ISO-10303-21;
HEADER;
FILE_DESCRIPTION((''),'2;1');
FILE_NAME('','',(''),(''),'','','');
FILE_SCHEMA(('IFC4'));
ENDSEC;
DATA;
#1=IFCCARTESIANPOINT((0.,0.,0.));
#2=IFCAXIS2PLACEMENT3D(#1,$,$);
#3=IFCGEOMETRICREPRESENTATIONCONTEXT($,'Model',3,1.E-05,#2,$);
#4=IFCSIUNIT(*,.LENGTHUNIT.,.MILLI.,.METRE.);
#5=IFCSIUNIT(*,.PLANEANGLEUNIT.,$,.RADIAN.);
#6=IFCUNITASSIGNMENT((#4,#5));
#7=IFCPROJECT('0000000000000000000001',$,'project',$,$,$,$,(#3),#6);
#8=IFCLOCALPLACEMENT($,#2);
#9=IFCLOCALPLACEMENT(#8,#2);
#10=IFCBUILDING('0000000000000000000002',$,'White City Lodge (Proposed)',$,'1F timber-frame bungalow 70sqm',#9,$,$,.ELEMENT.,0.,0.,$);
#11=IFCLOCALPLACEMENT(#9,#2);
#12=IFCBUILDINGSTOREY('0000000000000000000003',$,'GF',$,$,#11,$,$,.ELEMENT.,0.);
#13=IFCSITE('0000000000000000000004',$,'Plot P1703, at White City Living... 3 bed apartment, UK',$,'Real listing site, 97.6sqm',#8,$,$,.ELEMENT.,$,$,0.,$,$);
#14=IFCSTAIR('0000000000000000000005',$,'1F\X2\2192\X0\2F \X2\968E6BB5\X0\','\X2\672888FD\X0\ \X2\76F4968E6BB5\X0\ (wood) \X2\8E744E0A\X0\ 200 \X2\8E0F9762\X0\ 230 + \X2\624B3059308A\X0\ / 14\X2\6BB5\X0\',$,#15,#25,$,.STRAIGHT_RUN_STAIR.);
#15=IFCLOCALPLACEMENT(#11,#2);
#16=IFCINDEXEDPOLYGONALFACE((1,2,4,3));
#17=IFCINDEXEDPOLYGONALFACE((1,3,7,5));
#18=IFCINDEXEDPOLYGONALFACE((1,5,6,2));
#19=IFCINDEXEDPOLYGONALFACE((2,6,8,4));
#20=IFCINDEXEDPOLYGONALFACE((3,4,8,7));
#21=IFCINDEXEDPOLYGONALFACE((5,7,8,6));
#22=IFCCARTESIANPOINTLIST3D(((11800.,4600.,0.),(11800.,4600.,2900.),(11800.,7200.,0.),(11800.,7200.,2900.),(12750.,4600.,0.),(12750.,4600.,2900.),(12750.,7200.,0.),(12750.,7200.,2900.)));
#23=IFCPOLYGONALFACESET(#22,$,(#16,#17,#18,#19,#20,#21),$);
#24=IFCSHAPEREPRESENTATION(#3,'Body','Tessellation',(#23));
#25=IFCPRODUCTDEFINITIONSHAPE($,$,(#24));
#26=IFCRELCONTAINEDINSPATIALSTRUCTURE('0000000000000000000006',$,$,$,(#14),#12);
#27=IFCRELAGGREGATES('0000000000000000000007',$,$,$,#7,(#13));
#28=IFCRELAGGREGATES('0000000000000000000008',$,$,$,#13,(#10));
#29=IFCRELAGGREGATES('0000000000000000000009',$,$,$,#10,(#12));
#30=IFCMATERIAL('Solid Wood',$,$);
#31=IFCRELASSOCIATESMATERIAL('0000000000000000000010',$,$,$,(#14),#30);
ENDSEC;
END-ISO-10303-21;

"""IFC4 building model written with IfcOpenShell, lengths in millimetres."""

from ifc_helpers import new_model, si_unit, frame, frame_2d, origin, place, context, project, spatial, rectangle, extrude, material, element, save


model = new_model("IFC4")

# Units and contexts
model_context = context("Model", 3, precision=1e-05, world=origin())
ifc_project = project(units=[si_unit("LENGTHUNIT", "METRE", prefix="MILLI"), si_unit("PLANEANGLEUNIT", "RADIAN")], contexts=[model_context])

# Site, building, storey
site_placement = place(None, origin())
site = spatial("IfcSite", under=ifc_project, at=site_placement, Name="Plot P1703, at White City Living... 3 bed apartment, UK", ObjectType="Real listing site, 97.6sqm", CompositionType="ELEMENT", RefElevation=0.0)
building_placement = place(site_placement, origin())
building = spatial("IfcBuilding", under=site, at=building_placement, Name="White City Lodge (Proposed)", ObjectType="1F timber-frame bungalow 70sqm", CompositionType="ELEMENT", ElevationOfRefHeight=0.0, ElevationOfTerrain=0.0)
storey_placement = place(building_placement, origin())
storey = spatial("IfcBuildingStorey", under=building, at=storey_placement, Name="GF", CompositionType="ELEMENT", Elevation=0.0)

# Shared definitions
ifc_material_1 = material(Name="Solid Wood")

# Stair
stair_placement = place(storey_placement, frame((5900.0, 2300.0, 0.0)))
element("IfcStair", 1, at=stair_placement, inside=storey, material=ifc_material_1, Name="1F→2F 階段", Description="木製 直階段 (wood) 蹴上 200 踏面 230 + 手すり / 14段", PredefinedType="STRAIGHT_RUN_STAIR", context=model_context, shape_type="SweptSolid", body=[
    extrude(rectangle(XDim=950.0, YDim=2600.0, at=frame_2d((475.0, 1300.0))), frame((5900.0, 2300.0, 0.0)), (0.0, 0.0, 1.0), 2900.0),
])

save(model, "model.ifc")
